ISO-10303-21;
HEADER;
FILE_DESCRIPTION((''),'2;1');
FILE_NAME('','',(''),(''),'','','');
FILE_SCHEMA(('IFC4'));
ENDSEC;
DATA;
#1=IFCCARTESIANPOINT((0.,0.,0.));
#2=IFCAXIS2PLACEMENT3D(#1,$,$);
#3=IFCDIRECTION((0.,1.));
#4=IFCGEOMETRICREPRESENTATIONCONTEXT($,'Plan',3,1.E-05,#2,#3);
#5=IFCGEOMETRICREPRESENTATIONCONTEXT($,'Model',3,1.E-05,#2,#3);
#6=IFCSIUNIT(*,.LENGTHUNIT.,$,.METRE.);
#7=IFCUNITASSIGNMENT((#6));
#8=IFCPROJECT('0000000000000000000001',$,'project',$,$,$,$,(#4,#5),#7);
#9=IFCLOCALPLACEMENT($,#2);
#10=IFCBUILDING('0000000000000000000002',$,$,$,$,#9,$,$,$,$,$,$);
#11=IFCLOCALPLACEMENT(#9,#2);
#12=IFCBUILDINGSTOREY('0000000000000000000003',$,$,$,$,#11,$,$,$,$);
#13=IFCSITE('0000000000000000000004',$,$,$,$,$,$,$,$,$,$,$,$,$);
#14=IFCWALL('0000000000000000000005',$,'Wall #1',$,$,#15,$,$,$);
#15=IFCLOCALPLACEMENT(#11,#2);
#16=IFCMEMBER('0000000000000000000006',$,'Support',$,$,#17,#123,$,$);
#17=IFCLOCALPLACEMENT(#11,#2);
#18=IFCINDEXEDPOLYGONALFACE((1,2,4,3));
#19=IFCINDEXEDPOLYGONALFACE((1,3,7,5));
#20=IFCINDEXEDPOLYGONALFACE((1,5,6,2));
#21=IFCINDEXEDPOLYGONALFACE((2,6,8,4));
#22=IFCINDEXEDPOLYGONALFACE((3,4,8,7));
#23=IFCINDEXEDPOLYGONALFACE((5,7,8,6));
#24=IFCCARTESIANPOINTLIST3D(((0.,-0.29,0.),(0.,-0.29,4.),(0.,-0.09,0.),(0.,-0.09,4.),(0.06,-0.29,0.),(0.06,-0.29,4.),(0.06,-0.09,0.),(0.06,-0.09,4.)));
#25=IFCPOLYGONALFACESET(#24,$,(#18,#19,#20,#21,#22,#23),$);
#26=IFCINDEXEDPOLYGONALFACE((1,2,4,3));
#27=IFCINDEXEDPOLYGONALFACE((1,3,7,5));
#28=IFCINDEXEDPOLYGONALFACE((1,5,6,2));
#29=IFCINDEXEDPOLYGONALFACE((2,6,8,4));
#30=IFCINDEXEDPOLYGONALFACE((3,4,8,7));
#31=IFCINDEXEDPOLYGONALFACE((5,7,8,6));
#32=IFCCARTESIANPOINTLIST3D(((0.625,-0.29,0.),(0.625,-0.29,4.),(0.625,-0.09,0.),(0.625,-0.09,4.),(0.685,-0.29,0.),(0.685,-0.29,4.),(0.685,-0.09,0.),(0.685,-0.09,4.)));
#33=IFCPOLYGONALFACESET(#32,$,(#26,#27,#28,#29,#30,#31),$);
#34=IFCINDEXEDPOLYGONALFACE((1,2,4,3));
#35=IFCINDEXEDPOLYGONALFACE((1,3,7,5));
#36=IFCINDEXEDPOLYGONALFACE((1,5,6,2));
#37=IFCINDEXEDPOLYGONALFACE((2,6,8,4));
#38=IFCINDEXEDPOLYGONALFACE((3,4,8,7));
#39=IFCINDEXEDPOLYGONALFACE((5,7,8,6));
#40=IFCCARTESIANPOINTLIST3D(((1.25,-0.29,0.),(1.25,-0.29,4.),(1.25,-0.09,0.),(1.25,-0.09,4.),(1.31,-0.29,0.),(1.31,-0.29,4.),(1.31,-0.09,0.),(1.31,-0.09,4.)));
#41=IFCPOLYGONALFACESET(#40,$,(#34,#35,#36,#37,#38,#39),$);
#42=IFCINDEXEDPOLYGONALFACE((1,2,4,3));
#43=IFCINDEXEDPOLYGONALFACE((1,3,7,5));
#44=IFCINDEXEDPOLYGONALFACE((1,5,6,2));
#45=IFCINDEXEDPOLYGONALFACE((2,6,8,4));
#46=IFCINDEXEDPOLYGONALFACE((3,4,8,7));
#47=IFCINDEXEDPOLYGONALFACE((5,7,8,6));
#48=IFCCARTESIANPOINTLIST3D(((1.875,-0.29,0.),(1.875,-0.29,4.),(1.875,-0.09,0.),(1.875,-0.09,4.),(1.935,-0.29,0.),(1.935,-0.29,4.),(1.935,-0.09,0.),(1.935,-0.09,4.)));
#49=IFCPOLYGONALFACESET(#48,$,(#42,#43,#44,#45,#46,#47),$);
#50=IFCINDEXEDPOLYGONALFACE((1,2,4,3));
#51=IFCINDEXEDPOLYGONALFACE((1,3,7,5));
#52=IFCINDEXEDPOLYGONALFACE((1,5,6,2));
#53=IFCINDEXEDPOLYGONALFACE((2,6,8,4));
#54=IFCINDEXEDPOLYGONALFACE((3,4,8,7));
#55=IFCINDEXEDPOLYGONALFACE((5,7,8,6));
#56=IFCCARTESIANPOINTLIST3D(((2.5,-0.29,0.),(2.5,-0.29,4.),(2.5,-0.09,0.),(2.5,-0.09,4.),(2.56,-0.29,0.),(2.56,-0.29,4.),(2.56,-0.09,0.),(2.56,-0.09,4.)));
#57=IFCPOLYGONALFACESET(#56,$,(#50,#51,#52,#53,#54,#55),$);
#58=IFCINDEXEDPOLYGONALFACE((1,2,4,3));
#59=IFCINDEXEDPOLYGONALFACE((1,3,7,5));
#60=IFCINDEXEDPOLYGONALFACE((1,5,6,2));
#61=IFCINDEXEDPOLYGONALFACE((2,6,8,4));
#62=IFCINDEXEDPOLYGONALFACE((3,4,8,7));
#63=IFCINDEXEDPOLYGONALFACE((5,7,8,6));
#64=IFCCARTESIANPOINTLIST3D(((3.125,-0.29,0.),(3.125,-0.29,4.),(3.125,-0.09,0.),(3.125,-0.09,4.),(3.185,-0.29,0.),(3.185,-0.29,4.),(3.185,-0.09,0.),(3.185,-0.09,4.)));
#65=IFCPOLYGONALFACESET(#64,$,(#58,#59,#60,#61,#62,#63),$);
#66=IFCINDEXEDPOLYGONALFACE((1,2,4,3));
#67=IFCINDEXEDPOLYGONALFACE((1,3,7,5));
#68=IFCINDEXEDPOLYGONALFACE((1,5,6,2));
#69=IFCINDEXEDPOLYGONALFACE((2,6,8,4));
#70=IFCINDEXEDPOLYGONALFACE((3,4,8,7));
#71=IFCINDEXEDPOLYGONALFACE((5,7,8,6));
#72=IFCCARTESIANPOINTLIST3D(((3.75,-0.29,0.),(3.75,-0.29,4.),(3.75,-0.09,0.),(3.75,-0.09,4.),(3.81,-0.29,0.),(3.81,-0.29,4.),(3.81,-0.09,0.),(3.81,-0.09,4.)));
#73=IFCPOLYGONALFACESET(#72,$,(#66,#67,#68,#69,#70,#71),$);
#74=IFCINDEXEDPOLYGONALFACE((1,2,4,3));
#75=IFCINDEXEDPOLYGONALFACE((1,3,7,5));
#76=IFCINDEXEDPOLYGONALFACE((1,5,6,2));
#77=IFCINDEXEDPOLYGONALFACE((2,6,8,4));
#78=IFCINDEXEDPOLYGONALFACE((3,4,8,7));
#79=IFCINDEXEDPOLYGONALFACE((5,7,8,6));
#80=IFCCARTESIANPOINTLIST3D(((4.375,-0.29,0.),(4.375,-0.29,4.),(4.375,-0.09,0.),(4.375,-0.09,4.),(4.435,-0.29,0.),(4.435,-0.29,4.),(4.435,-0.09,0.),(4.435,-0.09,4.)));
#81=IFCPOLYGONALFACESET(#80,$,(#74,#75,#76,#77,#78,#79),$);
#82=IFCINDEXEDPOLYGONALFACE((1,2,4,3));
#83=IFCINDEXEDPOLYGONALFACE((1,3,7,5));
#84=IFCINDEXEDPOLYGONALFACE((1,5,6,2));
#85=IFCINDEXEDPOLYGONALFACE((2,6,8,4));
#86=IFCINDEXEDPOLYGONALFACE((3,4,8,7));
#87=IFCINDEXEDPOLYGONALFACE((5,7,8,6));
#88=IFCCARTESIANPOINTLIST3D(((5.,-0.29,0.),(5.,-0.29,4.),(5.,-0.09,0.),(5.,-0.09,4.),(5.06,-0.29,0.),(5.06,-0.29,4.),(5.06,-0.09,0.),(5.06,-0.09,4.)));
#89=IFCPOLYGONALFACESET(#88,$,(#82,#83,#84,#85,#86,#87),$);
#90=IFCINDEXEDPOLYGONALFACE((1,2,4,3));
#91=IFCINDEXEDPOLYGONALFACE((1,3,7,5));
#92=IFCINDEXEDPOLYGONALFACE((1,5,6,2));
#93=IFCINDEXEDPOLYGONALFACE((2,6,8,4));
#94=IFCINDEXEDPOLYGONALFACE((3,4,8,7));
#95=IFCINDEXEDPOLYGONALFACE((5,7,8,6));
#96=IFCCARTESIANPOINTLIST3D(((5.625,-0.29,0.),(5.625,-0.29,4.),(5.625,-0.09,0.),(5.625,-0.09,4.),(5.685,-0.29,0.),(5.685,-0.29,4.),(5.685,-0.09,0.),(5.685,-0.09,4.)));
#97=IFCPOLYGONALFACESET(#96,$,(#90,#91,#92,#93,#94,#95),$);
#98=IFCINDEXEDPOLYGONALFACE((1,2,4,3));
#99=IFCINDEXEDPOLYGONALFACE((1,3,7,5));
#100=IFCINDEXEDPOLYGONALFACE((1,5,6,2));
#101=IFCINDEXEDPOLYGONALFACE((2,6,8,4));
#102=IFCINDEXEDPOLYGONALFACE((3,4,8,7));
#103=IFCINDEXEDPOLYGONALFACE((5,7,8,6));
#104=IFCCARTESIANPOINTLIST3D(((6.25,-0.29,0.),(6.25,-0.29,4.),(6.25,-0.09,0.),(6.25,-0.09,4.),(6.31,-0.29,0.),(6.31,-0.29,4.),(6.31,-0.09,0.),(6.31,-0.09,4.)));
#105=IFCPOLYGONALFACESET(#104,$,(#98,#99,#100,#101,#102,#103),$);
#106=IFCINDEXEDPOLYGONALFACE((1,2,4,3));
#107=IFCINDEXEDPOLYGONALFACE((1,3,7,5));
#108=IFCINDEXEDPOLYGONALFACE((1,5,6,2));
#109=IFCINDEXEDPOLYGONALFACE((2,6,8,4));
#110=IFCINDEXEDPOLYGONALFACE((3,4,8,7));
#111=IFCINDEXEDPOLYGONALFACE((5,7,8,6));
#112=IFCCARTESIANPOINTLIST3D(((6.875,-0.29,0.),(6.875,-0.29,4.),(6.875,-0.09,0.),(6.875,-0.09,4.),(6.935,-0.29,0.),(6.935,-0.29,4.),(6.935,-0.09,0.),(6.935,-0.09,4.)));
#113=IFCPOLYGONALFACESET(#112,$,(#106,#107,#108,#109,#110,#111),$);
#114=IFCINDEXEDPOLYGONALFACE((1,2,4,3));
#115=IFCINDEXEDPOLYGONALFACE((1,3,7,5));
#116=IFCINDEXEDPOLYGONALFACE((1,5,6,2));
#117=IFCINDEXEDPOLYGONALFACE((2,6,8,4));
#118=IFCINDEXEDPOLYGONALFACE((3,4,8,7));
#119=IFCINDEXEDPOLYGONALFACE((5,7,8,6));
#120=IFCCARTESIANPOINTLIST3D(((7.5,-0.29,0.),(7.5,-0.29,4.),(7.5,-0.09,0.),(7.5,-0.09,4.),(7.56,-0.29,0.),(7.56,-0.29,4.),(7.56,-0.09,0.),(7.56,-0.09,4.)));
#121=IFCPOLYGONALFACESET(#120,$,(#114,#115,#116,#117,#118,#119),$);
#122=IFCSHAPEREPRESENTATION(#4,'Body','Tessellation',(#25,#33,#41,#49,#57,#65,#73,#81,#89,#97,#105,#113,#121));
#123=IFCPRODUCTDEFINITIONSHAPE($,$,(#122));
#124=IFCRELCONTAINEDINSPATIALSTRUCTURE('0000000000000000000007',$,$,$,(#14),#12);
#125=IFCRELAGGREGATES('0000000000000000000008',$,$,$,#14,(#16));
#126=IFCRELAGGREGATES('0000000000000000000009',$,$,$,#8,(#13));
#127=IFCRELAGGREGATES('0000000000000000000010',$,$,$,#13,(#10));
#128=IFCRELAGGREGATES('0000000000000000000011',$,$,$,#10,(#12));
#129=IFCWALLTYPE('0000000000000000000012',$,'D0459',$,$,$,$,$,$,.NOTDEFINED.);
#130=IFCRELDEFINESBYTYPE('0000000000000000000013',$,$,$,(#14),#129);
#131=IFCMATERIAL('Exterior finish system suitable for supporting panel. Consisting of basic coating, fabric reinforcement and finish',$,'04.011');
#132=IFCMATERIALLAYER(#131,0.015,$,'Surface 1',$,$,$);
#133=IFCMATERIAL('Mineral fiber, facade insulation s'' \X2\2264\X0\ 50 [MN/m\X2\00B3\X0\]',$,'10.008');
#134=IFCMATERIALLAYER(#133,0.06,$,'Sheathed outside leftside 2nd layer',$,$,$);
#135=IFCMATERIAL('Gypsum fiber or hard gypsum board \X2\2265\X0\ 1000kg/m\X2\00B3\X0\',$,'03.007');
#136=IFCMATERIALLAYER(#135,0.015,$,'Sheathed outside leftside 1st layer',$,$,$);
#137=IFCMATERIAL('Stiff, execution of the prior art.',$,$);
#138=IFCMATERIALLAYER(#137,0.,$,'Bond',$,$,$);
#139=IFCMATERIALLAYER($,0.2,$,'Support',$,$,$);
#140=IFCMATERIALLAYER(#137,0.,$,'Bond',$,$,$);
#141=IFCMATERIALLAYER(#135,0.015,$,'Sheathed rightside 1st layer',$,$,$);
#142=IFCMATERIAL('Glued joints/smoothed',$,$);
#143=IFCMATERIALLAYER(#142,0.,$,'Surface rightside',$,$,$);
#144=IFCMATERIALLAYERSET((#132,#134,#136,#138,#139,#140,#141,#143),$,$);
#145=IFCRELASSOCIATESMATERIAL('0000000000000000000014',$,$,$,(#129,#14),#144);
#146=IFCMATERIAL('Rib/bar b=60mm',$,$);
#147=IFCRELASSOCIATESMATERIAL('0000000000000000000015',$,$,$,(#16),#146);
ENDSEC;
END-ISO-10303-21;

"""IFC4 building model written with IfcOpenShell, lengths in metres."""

from ifc_helpers import new_model, si_unit, direction, frame, frame_2d, origin, place, context, project, spatial, rectangle, extrude, material, layer, layer_set, type_object, element, aggregate, save


model = new_model("IFC4")

# Units and contexts
plan_context = context("Plan", 3, precision=1e-05, world=origin(), true_north=direction((0.0, 1.0)))
model_context = context("Model", 3, precision=1e-05, world=origin(), true_north=direction((0.0, 1.0)))
ifc_project = project(units=[si_unit("LENGTHUNIT", "METRE")], contexts=[plan_context, model_context])

# Site, building, storey
site = spatial("IfcSite", under=ifc_project)
building_placement = place(None, origin())
building = spatial("IfcBuilding", under=site, at=building_placement)
storey_placement = place(building_placement, origin())
storey = spatial("IfcBuildingStorey", under=building, at=storey_placement)

# Wall, member
ifc_material_1 = material(Name="Exterior finish system suitable for supporting panel. Consisting of basic coating, fabric reinforcement and finish", Category="04.011")
ifc_layer_1 = layer(ifc_material_1, 0.015, Name="Surface 1")
ifc_material_2 = material(Name="Mineral fiber, facade insulation s' ≤ 50 [MN/m³]", Category="10.008")
ifc_layer_2 = layer(ifc_material_2, 0.06, Name="Sheathed outside leftside 2nd layer")
ifc_material_3 = material(Name="Gypsum fiber or hard gypsum board ≥ 1000kg/m³", Category="03.007")
ifc_layer_3 = layer(ifc_material_3, 0.015, Name="Sheathed outside leftside 1st layer")
ifc_material_4 = material(Name="Stiff, execution of the prior art.")
ifc_layer_4 = layer(ifc_material_4, 0.0, Name="Bond")
ifc_layer_5 = layer(None, 0.2, Name="Support")
ifc_layer_6 = layer(ifc_material_4, 0.0, Name="Bond")
ifc_layer_7 = layer(ifc_material_3, 0.015, Name="Sheathed rightside 1st layer")
ifc_material_5 = material(Name="Glued joints/smoothed")
ifc_layer_8 = layer(ifc_material_5, 0.0, Name="Surface rightside")
ifc_layer_set = layer_set([ifc_layer_1, ifc_layer_2, ifc_layer_3, ifc_layer_4, ifc_layer_5, ifc_layer_6, ifc_layer_7, ifc_layer_8])
wall_type = type_object("IfcWallType", Name="D0459", PredefinedType="NOTDEFINED", material=ifc_layer_set)
wall_placement = place(None, frame((0.0, 0.0, 0.0), z_axis=(0.0, -1.0, 0.0), x_axis=(1.0, 0.0, 0.0)))
wall = element("IfcWall", 1, at=wall_placement, inside=storey, type_object=wall_type, material=ifc_layer_set, Name="Wall #1")
ifc_material_6 = material(Name="Rib/bar b=60mm")
member_1_placement = place(wall_placement, origin())
member_1 = element("IfcMember", 2, at=member_1_placement, material=ifc_material_6, Name="Support", context=plan_context, shape_type="SweptSolid", body=[
    extrude(rectangle(XDim=0.06, YDim=0.2, at=frame_2d((0.03, 0.1), x_axis=(1.0, 0.0))), frame((0.0, 4.0, 0.09), z_axis=(0.0, -1.0, 0.0), x_axis=(1.0, 0.0, 0.0)), (0.0, 0.0, 1.0), 4.0),
    extrude(rectangle(XDim=0.06, YDim=0.2, at=frame_2d((0.03, 0.1), x_axis=(1.0, 0.0))), frame((0.625, 4.0, 0.09), z_axis=(0.0, -1.0, 0.0), x_axis=(1.0, 0.0, 0.0)), (0.0, 0.0, 1.0), 4.0),
    extrude(rectangle(XDim=0.06, YDim=0.2, at=frame_2d((0.03, 0.1), x_axis=(1.0, 0.0))), frame((1.25, 4.0, 0.09), z_axis=(0.0, -1.0, 0.0), x_axis=(1.0, 0.0, 0.0)), (0.0, 0.0, 1.0), 4.0),
    extrude(rectangle(XDim=0.06, YDim=0.2, at=frame_2d((0.03, 0.1), x_axis=(1.0, 0.0))), frame((1.875, 4.0, 0.09), z_axis=(0.0, -1.0, 0.0), x_axis=(1.0, 0.0, 0.0)), (0.0, 0.0, 1.0), 4.0),
    extrude(rectangle(XDim=0.06, YDim=0.2, at=frame_2d((0.03, 0.1), x_axis=(1.0, 0.0))), frame((2.5, 4.0, 0.09), z_axis=(0.0, -1.0, 0.0), x_axis=(1.0, 0.0, 0.0)), (0.0, 0.0, 1.0), 4.0),
    extrude(rectangle(XDim=0.06, YDim=0.2, at=frame_2d((0.03, 0.1), x_axis=(1.0, 0.0))), frame((3.125, 4.0, 0.09), z_axis=(0.0, -1.0, 0.0), x_axis=(1.0, 0.0, 0.0)), (0.0, 0.0, 1.0), 4.0),
    extrude(rectangle(XDim=0.06, YDim=0.2, at=frame_2d((0.03, 0.1), x_axis=(1.0, 0.0))), frame((3.75, 4.0, 0.09), z_axis=(0.0, -1.0, 0.0), x_axis=(1.0, 0.0, 0.0)), (0.0, 0.0, 1.0), 4.0),
    extrude(rectangle(XDim=0.06, YDim=0.2, at=frame_2d((0.03, 0.1), x_axis=(1.0, 0.0))), frame((4.375, 4.0, 0.09), z_axis=(0.0, -1.0, 0.0), x_axis=(1.0, 0.0, 0.0)), (0.0, 0.0, 1.0), 4.0),
    extrude(rectangle(XDim=0.06, YDim=0.2, at=frame_2d((0.03, 0.1), x_axis=(1.0, 0.0))), frame((5.0, 4.0, 0.09), z_axis=(0.0, -1.0, 0.0), x_axis=(1.0, 0.0, 0.0)), (0.0, 0.0, 1.0), 4.0),
    extrude(rectangle(XDim=0.06, YDim=0.2, at=frame_2d((0.03, 0.1), x_axis=(1.0, 0.0))), frame((5.625, 4.0, 0.09), z_axis=(0.0, -1.0, 0.0), x_axis=(1.0, 0.0, 0.0)), (0.0, 0.0, 1.0), 4.0),
    extrude(rectangle(XDim=0.06, YDim=0.2, at=frame_2d((0.03, 0.1), x_axis=(1.0, 0.0))), frame((6.25, 4.0, 0.09), z_axis=(0.0, -1.0, 0.0), x_axis=(1.0, 0.0, 0.0)), (0.0, 0.0, 1.0), 4.0),
    extrude(rectangle(XDim=0.06, YDim=0.2, at=frame_2d((0.03, 0.1), x_axis=(1.0, 0.0))), frame((6.875, 4.0, 0.09), z_axis=(0.0, -1.0, 0.0), x_axis=(1.0, 0.0, 0.0)), (0.0, 0.0, 1.0), 4.0),
    extrude(rectangle(XDim=0.06, YDim=0.2, at=frame_2d((0.03, 0.1), x_axis=(1.0, 0.0))), frame((7.5, 4.0, 0.09), z_axis=(0.0, -1.0, 0.0), x_axis=(1.0, 0.0, 0.0)), (0.0, 0.0, 1.0), 4.0),
])
aggregate(wall, [member_1])

save(model, "model.ifc")
